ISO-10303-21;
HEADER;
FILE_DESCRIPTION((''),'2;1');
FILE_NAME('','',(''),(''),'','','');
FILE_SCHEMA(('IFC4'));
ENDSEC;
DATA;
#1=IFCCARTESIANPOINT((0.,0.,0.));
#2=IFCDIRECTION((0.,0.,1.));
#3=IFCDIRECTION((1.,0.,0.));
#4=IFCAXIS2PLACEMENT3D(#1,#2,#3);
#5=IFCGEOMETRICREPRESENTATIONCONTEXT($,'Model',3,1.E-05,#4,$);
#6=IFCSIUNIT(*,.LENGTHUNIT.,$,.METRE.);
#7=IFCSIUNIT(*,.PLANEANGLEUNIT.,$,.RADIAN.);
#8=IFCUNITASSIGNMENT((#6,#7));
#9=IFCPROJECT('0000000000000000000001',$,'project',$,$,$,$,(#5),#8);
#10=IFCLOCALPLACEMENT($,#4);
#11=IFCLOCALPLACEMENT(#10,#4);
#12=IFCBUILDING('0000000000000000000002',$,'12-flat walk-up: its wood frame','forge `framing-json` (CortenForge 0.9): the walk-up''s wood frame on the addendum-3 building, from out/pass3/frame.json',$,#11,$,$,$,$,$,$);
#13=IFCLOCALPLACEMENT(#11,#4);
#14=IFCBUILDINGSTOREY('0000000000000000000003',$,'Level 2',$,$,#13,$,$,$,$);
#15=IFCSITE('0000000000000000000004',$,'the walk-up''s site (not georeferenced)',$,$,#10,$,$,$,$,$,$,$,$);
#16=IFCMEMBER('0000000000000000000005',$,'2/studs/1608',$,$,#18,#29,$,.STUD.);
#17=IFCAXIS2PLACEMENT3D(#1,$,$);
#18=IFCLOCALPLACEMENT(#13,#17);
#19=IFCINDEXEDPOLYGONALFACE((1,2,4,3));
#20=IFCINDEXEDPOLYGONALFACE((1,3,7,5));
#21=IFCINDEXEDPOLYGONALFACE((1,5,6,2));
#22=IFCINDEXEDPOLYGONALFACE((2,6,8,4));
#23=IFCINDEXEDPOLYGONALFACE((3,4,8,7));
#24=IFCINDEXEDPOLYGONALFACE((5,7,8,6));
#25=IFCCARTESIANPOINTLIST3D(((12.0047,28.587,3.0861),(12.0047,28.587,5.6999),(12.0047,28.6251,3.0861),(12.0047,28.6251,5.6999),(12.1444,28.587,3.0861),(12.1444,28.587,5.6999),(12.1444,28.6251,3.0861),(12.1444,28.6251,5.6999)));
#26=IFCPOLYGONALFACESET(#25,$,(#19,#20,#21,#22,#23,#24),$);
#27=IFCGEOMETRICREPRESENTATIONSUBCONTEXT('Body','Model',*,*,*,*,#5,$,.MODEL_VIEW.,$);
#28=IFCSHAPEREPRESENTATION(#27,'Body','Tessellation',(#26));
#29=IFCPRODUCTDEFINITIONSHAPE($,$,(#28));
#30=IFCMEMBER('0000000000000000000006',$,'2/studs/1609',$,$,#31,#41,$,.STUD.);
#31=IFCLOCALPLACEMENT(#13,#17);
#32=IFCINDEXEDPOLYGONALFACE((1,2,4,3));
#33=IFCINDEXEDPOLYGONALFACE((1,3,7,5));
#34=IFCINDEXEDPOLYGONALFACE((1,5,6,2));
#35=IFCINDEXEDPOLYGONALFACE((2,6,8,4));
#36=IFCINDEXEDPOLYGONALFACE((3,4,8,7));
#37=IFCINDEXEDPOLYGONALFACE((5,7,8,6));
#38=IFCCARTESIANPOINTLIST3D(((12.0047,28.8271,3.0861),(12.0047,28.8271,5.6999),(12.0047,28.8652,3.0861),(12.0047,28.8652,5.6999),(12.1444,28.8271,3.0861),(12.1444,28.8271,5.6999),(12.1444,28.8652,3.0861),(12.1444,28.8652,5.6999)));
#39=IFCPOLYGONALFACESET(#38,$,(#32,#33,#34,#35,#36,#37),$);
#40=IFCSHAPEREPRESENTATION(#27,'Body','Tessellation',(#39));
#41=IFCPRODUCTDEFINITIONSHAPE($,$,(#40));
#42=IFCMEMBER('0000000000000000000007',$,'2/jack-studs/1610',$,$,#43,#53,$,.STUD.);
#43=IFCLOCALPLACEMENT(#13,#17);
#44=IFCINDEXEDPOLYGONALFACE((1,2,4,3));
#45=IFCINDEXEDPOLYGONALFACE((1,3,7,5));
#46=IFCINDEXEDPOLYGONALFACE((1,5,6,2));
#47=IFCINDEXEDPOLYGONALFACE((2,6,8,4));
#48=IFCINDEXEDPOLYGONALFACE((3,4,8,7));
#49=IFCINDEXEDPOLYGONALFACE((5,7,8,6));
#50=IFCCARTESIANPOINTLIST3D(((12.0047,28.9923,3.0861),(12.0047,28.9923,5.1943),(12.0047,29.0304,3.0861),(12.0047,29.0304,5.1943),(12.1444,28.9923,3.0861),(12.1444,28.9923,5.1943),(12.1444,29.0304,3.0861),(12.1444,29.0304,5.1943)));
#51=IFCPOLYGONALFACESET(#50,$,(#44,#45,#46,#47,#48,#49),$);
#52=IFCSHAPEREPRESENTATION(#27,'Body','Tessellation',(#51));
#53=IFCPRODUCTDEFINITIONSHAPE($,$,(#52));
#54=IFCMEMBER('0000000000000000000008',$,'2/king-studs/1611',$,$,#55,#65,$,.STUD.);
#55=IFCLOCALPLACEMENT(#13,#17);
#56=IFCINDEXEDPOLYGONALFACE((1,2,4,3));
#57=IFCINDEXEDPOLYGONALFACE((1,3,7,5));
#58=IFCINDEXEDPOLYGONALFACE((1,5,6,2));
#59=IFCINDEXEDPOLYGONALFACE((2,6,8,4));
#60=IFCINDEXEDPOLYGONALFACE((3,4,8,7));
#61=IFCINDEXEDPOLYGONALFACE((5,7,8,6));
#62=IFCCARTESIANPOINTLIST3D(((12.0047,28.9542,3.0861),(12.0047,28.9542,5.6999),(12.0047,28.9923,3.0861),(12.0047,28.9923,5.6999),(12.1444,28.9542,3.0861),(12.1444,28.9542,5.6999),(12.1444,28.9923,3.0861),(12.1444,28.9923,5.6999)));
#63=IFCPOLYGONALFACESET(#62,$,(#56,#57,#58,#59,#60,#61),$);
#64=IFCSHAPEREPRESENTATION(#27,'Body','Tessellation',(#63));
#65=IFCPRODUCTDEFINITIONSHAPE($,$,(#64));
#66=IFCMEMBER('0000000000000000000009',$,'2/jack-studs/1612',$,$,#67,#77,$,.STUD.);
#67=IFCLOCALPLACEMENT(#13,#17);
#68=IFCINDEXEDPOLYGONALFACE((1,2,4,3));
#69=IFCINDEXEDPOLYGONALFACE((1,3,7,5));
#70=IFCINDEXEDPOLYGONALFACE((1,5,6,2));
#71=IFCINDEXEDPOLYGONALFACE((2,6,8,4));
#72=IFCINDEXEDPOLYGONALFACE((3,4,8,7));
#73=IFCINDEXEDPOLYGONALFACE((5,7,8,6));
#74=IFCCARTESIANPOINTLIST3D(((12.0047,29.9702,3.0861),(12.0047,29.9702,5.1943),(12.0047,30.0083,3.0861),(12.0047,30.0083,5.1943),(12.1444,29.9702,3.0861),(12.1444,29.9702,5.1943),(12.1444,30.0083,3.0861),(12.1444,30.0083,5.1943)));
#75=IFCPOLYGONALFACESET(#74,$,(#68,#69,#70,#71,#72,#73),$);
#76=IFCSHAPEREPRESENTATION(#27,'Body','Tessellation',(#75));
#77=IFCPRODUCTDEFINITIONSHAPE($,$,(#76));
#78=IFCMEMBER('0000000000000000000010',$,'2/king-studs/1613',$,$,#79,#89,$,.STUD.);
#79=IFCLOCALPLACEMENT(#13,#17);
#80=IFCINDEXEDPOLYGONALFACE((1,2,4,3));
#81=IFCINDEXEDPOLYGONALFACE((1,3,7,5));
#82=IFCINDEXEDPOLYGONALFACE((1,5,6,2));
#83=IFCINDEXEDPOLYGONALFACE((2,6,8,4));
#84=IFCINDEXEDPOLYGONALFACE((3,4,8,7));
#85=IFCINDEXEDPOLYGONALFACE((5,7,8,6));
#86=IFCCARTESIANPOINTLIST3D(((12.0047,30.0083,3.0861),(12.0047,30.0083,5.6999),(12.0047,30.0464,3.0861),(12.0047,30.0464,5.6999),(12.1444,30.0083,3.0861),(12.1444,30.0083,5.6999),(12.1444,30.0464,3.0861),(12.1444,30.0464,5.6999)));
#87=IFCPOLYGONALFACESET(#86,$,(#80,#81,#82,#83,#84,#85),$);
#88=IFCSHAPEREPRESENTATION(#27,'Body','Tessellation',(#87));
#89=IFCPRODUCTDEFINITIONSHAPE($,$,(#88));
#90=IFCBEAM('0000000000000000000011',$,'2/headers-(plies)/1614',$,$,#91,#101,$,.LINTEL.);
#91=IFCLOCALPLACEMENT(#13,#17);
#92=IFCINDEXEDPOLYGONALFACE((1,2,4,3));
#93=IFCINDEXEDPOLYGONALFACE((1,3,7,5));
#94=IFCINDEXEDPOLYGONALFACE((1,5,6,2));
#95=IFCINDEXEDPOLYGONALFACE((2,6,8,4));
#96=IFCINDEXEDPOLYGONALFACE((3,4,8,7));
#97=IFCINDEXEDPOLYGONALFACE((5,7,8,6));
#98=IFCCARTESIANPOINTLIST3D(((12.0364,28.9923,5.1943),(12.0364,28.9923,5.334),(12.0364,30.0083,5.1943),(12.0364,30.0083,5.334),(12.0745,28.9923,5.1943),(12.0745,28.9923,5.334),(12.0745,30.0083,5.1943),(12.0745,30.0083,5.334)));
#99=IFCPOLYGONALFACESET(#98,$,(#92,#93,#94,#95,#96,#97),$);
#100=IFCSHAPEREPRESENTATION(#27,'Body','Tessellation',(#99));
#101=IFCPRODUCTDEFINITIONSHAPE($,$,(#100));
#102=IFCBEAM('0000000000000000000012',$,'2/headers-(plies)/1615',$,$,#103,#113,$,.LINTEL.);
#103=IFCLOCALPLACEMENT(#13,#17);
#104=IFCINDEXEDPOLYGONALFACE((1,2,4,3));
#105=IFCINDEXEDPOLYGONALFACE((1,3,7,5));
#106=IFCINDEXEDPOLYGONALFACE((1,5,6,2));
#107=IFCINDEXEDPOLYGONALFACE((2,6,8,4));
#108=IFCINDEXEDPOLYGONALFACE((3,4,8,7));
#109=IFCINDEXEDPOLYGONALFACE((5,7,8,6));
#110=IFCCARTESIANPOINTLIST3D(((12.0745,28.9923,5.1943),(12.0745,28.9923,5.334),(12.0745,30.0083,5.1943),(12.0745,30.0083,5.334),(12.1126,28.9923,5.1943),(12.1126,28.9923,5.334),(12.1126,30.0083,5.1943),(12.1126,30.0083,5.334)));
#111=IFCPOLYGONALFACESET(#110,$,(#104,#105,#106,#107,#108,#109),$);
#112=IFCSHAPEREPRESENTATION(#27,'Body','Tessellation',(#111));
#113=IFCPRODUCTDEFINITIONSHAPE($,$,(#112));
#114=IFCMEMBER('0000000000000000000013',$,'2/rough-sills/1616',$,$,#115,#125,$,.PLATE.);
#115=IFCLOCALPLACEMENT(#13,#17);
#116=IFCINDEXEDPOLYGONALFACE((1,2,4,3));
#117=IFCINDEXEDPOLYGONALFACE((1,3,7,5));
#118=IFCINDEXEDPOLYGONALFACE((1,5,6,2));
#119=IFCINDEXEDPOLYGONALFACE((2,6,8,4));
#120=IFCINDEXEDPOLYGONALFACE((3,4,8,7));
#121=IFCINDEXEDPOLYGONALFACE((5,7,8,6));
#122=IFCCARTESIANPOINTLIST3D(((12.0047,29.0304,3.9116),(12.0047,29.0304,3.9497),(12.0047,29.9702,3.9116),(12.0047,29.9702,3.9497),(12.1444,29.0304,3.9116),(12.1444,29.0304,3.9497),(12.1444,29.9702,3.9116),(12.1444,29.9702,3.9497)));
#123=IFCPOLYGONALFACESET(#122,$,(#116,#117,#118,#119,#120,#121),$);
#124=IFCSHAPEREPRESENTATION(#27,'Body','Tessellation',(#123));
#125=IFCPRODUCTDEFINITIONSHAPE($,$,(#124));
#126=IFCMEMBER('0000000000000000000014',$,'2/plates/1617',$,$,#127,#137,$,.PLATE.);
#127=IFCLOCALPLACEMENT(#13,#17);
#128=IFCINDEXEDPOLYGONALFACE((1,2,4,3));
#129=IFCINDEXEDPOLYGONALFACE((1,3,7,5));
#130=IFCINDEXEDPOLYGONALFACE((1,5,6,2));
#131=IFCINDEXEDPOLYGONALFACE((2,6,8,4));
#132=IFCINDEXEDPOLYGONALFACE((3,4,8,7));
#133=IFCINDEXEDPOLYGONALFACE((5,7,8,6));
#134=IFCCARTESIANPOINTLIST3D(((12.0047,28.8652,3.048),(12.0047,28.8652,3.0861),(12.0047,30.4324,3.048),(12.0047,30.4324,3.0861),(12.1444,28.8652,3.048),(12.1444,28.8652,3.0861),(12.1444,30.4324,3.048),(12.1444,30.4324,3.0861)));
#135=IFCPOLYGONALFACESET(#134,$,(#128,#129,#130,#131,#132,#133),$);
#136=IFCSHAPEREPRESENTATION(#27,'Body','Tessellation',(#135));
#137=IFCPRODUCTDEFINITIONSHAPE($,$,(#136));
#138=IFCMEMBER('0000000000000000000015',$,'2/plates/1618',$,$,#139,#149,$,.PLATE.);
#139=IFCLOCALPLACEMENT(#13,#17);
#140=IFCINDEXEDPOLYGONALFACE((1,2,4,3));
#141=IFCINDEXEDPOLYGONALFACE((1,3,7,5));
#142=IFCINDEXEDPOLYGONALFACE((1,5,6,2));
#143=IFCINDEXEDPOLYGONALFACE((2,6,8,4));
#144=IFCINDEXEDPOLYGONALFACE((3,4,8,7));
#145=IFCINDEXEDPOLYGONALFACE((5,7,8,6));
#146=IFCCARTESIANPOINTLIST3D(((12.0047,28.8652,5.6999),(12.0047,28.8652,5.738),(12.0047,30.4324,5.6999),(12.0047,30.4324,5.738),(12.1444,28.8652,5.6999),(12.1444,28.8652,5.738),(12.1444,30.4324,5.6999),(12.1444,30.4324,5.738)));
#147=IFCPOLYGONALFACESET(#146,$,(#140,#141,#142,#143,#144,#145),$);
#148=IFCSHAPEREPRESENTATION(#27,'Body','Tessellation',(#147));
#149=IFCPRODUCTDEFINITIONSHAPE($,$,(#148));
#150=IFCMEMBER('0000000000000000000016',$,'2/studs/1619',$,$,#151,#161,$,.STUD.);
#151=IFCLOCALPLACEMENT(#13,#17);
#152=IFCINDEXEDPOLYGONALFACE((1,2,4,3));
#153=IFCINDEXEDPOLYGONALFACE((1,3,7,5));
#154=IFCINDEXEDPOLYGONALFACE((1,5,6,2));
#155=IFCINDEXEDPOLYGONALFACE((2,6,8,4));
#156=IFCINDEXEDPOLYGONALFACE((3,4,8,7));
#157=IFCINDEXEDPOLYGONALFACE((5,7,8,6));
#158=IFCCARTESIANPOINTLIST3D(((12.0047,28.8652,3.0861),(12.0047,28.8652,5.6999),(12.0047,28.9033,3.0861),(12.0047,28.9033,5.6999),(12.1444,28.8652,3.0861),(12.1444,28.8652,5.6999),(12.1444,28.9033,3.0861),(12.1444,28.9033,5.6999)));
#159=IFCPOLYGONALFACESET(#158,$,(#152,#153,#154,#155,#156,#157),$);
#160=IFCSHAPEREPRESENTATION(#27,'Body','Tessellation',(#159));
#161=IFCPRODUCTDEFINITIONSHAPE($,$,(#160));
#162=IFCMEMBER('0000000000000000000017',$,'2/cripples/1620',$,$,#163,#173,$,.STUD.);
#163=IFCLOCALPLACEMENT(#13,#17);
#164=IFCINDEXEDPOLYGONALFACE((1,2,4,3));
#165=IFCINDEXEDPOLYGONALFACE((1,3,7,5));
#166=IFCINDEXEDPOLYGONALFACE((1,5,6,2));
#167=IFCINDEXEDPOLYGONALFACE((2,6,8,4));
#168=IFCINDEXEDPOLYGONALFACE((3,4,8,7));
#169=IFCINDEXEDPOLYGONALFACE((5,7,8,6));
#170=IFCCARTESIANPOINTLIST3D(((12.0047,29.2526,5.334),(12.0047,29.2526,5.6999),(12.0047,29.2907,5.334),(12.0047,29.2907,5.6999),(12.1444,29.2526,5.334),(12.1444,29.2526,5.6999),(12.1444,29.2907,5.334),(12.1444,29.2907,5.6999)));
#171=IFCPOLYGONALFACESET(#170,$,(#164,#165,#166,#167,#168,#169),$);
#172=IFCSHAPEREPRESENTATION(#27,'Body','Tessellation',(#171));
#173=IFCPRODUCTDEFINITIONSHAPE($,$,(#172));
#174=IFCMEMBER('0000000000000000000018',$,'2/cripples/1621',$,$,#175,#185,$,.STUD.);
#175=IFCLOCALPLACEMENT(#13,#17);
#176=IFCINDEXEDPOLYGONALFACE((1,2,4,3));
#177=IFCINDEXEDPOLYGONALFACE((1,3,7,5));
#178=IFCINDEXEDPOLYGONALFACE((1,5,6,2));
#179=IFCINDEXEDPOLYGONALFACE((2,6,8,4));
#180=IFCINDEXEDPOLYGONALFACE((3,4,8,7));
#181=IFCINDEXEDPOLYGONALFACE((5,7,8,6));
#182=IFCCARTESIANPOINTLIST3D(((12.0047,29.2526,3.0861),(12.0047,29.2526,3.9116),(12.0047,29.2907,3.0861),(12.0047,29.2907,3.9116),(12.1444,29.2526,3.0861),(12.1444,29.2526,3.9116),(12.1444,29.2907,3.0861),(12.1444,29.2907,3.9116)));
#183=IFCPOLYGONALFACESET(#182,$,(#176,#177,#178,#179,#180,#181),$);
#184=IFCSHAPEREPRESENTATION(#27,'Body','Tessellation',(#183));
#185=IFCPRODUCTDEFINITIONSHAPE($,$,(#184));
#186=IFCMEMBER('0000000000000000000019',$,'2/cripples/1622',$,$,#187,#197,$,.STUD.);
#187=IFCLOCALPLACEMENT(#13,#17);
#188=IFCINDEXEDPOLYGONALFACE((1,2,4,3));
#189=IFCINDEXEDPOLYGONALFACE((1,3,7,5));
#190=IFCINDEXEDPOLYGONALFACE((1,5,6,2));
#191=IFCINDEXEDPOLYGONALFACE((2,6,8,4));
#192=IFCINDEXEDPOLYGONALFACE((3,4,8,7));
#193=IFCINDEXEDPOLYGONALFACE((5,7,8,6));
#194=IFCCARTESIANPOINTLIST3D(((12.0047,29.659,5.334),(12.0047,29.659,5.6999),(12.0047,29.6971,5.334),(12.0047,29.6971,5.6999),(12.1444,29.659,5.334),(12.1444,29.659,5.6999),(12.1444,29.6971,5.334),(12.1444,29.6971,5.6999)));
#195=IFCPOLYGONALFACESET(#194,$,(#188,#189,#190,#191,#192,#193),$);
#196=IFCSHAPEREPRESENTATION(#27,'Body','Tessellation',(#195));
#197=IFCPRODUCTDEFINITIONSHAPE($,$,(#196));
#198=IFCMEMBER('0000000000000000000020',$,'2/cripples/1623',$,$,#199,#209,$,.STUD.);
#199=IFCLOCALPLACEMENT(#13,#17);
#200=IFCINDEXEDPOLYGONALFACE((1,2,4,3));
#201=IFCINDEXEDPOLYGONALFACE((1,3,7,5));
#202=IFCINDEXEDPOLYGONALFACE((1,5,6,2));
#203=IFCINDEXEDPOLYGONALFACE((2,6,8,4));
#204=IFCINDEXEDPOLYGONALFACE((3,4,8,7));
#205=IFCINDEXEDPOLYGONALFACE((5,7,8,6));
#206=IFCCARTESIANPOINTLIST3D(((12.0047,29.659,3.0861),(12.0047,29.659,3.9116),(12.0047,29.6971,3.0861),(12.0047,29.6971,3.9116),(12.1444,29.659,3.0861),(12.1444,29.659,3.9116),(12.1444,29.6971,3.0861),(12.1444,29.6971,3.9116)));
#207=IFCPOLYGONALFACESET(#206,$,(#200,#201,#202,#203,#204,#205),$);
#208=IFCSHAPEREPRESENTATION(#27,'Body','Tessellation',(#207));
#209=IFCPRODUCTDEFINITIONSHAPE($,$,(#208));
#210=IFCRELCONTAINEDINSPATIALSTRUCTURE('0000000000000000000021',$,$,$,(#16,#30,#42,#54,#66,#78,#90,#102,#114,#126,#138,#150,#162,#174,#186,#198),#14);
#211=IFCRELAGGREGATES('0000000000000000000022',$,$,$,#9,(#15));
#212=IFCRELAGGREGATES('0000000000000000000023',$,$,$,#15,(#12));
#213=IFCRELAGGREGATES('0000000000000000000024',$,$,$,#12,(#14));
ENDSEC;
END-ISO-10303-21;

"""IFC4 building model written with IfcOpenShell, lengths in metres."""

from ifc_helpers import new_model, si_unit, frame, frame_2d, origin, origin_with_axes, place, context, subcontext, project, spatial, rectangle, extrude, element, save


model = new_model("IFC4")

# Units and contexts
model_context = context("Model", 3, precision=1e-05, world=origin_with_axes())
body_context = subcontext(model_context, "Body", "Model", "MODEL_VIEW")
ifc_project = project(units=[si_unit("LENGTHUNIT", "METRE"), si_unit("PLANEANGLEUNIT", "RADIAN")], contexts=[model_context])

# Site, building, storey
site_placement = place(None, origin_with_axes())
site = spatial("IfcSite", under=ifc_project, at=site_placement, Name="the walk-up's site (not georeferenced)")
building_placement = place(site_placement, origin_with_axes())
building = spatial("IfcBuilding", under=site, at=building_placement, Name="12-flat walk-up: its wood frame", Description="forge `framing-json` (CortenForge 0.9): the walk-up's wood frame on the addendum-3 building, from out/pass3/frame.json")
storey_placement = place(building_placement, origin_with_axes())
storey = spatial("IfcBuildingStorey", under=building, at=storey_placement, Name="Level 2")

# Members
for number, where, z_axis, x_axis, name in (
    (1, (12.0047, 28.587, 3.0861), (0.0, 0.0, 1.0), (1.0, 0.0, 0.0), "2/studs/1608"),
    (2, (12.0047, 28.8271, 3.0861), (0.0, 0.0, 1.0), (1.0, 0.0, 0.0), "2/studs/1609"),
):
    element("IfcMember", number, at=place(storey_placement, frame(where, z_axis=z_axis, x_axis=x_axis)), inside=storey, Name=name, PredefinedType="STUD", context=body_context, shape_type="SweptSolid", body=[
        extrude(rectangle(XDim=0.1397, YDim=0.0381, at=frame_2d((0.0698, 0.0191))), origin(), (0.0, 0.0, 1.0), 2.6138),
    ])
member_1_placement = place(storey_placement, frame((12.0047, 28.9923, 3.0861), z_axis=(0.0, 0.0, 1.0), x_axis=(1.0, 0.0, 0.0)))
element("IfcMember", 3, at=member_1_placement, inside=storey, Name="2/jack-studs/1610", PredefinedType="STUD", context=body_context, shape_type="SweptSolid", body=[
    extrude(rectangle(XDim=0.1397, YDim=0.0381, at=frame_2d((0.0698, 0.0191))), origin(), (0.0, 0.0, 1.0), 2.1082),
])
member_2_placement = place(storey_placement, frame((12.0047, 28.9542, 3.0861), z_axis=(0.0, 0.0, 1.0), x_axis=(1.0, 0.0, 0.0)))
element("IfcMember", 4, at=member_2_placement, inside=storey, Name="2/king-studs/1611", PredefinedType="STUD", context=body_context, shape_type="SweptSolid", body=[
    extrude(rectangle(XDim=0.1397, YDim=0.0381, at=frame_2d((0.0698, 0.0191))), origin(), (0.0, 0.0, 1.0), 2.6138),
])
member_3_placement = place(storey_placement, frame((12.0047, 29.9702, 3.0861), z_axis=(0.0, 0.0, 1.0), x_axis=(1.0, 0.0, 0.0)))
element("IfcMember", 5, at=member_3_placement, inside=storey, Name="2/jack-studs/1612", PredefinedType="STUD", context=body_context, shape_type="SweptSolid", body=[
    extrude(rectangle(XDim=0.1397, YDim=0.0381, at=frame_2d((0.0698, 0.019))), origin(), (0.0, 0.0, 1.0), 2.1082),
])
member_4_placement = place(storey_placement, frame((12.0047, 30.0083, 3.0861), z_axis=(0.0, 0.0, 1.0), x_axis=(1.0, 0.0, 0.0)))
element("IfcMember", 6, at=member_4_placement, inside=storey, Name="2/king-studs/1613", PredefinedType="STUD", context=body_context, shape_type="SweptSolid", body=[
    extrude(rectangle(XDim=0.1397, YDim=0.0381, at=frame_2d((0.0698, 0.0191))), origin(), (0.0, 0.0, 1.0), 2.6138),
])

# Beams
for number, where, z_axis, x_axis, name in (
    (7, (12.0364, 28.9923, 5.1943), (0.0, 0.0, 1.0), (1.0, 0.0, 0.0), "2/headers-(plies)/1614"),
    (8, (12.0745, 28.9923, 5.1943), (0.0, 0.0, 1.0), (1.0, 0.0, 0.0), "2/headers-(plies)/1615"),
):
    element("IfcBeam", number, at=place(storey_placement, frame(where, z_axis=z_axis, x_axis=x_axis)), inside=storey, Name=name, PredefinedType="LINTEL", context=body_context, shape_type="SweptSolid", body=[
        extrude(rectangle(XDim=0.0381, YDim=1.016, at=frame_2d((0.0191, 0.508))), origin(), (0.0, 0.0, 1.0), 0.1397),
    ])

# Members
member_5_placement = place(storey_placement, frame((12.0047, 29.0304, 3.9116), z_axis=(0.0, 0.0, 1.0), x_axis=(1.0, 0.0, 0.0)))
element("IfcMember", 9, at=member_5_placement, inside=storey, Name="2/rough-sills/1616", PredefinedType="PLATE", context=body_context, shape_type="SweptSolid", body=[
    extrude(rectangle(XDim=0.1397, YDim=0.9398, at=frame_2d((0.0698, 0.4699))), origin(), (0.0, 0.0, 1.0), 0.0381),
])
for number, where, z_axis, x_axis, name in (
    (10, (12.0047, 28.8652, 3.048), (0.0, 0.0, 1.0), (1.0, 0.0, 0.0), "2/plates/1617"),
    (11, (12.0047, 28.8652, 5.6999), (0.0, 0.0, 1.0), (1.0, 0.0, 0.0), "2/plates/1618"),
):
    element("IfcMember", number, at=place(storey_placement, frame(where, z_axis=z_axis, x_axis=x_axis)), inside=storey, Name=name, PredefinedType="PLATE", context=body_context, shape_type="SweptSolid", body=[
        extrude(rectangle(XDim=0.1397, YDim=1.5672, at=frame_2d((0.0698, 0.7836))), origin(), (0.0, 0.0, 1.0), 0.0381),
    ])
member_6_placement = place(storey_placement, frame((12.0047, 28.8652, 3.0861), z_axis=(0.0, 0.0, 1.0), x_axis=(1.0, 0.0, 0.0)))
element("IfcMember", 12, at=member_6_placement, inside=storey, Name="2/studs/1619", PredefinedType="STUD", context=body_context, shape_type="SweptSolid", body=[
    extrude(rectangle(XDim=0.1397, YDim=0.0381, at=frame_2d((0.0698, 0.0191))), origin(), (0.0, 0.0, 1.0), 2.6138),
])
member_7_placement = place(storey_placement, frame((12.0047, 29.2526, 5.334), z_axis=(0.0, 0.0, 1.0), x_axis=(1.0, 0.0, 0.0)))
element("IfcMember", 13, at=member_7_placement, inside=storey, Name="2/cripples/1620", PredefinedType="STUD", context=body_context, shape_type="SweptSolid", body=[
    extrude(rectangle(XDim=0.1397, YDim=0.0381, at=frame_2d((0.0698, 0.0191))), origin(), (0.0, 0.0, 1.0), 0.3659),
])
member_8_placement = place(storey_placement, frame((12.0047, 29.2526, 3.0861), z_axis=(0.0, 0.0, 1.0), x_axis=(1.0, 0.0, 0.0)))
element("IfcMember", 14, at=member_8_placement, inside=storey, Name="2/cripples/1621", PredefinedType="STUD", context=body_context, shape_type="SweptSolid", body=[
    extrude(rectangle(XDim=0.1397, YDim=0.0381, at=frame_2d((0.0698, 0.0191))), origin(), (0.0, 0.0, 1.0), 0.8255),
])
member_9_placement = place(storey_placement, frame((12.0047, 29.659, 5.334), z_axis=(0.0, 0.0, 1.0), x_axis=(1.0, 0.0, 0.0)))
element("IfcMember", 15, at=member_9_placement, inside=storey, Name="2/cripples/1622", PredefinedType="STUD", context=body_context, shape_type="SweptSolid", body=[
    extrude(rectangle(XDim=0.1397, YDim=0.0381, at=frame_2d((0.0698, 0.0191))), origin(), (0.0, 0.0, 1.0), 0.3659),
])
member_10_placement = place(storey_placement, frame((12.0047, 29.659, 3.0861), z_axis=(0.0, 0.0, 1.0), x_axis=(1.0, 0.0, 0.0)))
element("IfcMember", 16, at=member_10_placement, inside=storey, Name="2/cripples/1623", PredefinedType="STUD", context=body_context, shape_type="SweptSolid", body=[
    extrude(rectangle(XDim=0.1397, YDim=0.0381, at=frame_2d((0.0698, 0.0191))), origin(), (0.0, 0.0, 1.0), 0.8255),
])

save(model, "model.ifc")
